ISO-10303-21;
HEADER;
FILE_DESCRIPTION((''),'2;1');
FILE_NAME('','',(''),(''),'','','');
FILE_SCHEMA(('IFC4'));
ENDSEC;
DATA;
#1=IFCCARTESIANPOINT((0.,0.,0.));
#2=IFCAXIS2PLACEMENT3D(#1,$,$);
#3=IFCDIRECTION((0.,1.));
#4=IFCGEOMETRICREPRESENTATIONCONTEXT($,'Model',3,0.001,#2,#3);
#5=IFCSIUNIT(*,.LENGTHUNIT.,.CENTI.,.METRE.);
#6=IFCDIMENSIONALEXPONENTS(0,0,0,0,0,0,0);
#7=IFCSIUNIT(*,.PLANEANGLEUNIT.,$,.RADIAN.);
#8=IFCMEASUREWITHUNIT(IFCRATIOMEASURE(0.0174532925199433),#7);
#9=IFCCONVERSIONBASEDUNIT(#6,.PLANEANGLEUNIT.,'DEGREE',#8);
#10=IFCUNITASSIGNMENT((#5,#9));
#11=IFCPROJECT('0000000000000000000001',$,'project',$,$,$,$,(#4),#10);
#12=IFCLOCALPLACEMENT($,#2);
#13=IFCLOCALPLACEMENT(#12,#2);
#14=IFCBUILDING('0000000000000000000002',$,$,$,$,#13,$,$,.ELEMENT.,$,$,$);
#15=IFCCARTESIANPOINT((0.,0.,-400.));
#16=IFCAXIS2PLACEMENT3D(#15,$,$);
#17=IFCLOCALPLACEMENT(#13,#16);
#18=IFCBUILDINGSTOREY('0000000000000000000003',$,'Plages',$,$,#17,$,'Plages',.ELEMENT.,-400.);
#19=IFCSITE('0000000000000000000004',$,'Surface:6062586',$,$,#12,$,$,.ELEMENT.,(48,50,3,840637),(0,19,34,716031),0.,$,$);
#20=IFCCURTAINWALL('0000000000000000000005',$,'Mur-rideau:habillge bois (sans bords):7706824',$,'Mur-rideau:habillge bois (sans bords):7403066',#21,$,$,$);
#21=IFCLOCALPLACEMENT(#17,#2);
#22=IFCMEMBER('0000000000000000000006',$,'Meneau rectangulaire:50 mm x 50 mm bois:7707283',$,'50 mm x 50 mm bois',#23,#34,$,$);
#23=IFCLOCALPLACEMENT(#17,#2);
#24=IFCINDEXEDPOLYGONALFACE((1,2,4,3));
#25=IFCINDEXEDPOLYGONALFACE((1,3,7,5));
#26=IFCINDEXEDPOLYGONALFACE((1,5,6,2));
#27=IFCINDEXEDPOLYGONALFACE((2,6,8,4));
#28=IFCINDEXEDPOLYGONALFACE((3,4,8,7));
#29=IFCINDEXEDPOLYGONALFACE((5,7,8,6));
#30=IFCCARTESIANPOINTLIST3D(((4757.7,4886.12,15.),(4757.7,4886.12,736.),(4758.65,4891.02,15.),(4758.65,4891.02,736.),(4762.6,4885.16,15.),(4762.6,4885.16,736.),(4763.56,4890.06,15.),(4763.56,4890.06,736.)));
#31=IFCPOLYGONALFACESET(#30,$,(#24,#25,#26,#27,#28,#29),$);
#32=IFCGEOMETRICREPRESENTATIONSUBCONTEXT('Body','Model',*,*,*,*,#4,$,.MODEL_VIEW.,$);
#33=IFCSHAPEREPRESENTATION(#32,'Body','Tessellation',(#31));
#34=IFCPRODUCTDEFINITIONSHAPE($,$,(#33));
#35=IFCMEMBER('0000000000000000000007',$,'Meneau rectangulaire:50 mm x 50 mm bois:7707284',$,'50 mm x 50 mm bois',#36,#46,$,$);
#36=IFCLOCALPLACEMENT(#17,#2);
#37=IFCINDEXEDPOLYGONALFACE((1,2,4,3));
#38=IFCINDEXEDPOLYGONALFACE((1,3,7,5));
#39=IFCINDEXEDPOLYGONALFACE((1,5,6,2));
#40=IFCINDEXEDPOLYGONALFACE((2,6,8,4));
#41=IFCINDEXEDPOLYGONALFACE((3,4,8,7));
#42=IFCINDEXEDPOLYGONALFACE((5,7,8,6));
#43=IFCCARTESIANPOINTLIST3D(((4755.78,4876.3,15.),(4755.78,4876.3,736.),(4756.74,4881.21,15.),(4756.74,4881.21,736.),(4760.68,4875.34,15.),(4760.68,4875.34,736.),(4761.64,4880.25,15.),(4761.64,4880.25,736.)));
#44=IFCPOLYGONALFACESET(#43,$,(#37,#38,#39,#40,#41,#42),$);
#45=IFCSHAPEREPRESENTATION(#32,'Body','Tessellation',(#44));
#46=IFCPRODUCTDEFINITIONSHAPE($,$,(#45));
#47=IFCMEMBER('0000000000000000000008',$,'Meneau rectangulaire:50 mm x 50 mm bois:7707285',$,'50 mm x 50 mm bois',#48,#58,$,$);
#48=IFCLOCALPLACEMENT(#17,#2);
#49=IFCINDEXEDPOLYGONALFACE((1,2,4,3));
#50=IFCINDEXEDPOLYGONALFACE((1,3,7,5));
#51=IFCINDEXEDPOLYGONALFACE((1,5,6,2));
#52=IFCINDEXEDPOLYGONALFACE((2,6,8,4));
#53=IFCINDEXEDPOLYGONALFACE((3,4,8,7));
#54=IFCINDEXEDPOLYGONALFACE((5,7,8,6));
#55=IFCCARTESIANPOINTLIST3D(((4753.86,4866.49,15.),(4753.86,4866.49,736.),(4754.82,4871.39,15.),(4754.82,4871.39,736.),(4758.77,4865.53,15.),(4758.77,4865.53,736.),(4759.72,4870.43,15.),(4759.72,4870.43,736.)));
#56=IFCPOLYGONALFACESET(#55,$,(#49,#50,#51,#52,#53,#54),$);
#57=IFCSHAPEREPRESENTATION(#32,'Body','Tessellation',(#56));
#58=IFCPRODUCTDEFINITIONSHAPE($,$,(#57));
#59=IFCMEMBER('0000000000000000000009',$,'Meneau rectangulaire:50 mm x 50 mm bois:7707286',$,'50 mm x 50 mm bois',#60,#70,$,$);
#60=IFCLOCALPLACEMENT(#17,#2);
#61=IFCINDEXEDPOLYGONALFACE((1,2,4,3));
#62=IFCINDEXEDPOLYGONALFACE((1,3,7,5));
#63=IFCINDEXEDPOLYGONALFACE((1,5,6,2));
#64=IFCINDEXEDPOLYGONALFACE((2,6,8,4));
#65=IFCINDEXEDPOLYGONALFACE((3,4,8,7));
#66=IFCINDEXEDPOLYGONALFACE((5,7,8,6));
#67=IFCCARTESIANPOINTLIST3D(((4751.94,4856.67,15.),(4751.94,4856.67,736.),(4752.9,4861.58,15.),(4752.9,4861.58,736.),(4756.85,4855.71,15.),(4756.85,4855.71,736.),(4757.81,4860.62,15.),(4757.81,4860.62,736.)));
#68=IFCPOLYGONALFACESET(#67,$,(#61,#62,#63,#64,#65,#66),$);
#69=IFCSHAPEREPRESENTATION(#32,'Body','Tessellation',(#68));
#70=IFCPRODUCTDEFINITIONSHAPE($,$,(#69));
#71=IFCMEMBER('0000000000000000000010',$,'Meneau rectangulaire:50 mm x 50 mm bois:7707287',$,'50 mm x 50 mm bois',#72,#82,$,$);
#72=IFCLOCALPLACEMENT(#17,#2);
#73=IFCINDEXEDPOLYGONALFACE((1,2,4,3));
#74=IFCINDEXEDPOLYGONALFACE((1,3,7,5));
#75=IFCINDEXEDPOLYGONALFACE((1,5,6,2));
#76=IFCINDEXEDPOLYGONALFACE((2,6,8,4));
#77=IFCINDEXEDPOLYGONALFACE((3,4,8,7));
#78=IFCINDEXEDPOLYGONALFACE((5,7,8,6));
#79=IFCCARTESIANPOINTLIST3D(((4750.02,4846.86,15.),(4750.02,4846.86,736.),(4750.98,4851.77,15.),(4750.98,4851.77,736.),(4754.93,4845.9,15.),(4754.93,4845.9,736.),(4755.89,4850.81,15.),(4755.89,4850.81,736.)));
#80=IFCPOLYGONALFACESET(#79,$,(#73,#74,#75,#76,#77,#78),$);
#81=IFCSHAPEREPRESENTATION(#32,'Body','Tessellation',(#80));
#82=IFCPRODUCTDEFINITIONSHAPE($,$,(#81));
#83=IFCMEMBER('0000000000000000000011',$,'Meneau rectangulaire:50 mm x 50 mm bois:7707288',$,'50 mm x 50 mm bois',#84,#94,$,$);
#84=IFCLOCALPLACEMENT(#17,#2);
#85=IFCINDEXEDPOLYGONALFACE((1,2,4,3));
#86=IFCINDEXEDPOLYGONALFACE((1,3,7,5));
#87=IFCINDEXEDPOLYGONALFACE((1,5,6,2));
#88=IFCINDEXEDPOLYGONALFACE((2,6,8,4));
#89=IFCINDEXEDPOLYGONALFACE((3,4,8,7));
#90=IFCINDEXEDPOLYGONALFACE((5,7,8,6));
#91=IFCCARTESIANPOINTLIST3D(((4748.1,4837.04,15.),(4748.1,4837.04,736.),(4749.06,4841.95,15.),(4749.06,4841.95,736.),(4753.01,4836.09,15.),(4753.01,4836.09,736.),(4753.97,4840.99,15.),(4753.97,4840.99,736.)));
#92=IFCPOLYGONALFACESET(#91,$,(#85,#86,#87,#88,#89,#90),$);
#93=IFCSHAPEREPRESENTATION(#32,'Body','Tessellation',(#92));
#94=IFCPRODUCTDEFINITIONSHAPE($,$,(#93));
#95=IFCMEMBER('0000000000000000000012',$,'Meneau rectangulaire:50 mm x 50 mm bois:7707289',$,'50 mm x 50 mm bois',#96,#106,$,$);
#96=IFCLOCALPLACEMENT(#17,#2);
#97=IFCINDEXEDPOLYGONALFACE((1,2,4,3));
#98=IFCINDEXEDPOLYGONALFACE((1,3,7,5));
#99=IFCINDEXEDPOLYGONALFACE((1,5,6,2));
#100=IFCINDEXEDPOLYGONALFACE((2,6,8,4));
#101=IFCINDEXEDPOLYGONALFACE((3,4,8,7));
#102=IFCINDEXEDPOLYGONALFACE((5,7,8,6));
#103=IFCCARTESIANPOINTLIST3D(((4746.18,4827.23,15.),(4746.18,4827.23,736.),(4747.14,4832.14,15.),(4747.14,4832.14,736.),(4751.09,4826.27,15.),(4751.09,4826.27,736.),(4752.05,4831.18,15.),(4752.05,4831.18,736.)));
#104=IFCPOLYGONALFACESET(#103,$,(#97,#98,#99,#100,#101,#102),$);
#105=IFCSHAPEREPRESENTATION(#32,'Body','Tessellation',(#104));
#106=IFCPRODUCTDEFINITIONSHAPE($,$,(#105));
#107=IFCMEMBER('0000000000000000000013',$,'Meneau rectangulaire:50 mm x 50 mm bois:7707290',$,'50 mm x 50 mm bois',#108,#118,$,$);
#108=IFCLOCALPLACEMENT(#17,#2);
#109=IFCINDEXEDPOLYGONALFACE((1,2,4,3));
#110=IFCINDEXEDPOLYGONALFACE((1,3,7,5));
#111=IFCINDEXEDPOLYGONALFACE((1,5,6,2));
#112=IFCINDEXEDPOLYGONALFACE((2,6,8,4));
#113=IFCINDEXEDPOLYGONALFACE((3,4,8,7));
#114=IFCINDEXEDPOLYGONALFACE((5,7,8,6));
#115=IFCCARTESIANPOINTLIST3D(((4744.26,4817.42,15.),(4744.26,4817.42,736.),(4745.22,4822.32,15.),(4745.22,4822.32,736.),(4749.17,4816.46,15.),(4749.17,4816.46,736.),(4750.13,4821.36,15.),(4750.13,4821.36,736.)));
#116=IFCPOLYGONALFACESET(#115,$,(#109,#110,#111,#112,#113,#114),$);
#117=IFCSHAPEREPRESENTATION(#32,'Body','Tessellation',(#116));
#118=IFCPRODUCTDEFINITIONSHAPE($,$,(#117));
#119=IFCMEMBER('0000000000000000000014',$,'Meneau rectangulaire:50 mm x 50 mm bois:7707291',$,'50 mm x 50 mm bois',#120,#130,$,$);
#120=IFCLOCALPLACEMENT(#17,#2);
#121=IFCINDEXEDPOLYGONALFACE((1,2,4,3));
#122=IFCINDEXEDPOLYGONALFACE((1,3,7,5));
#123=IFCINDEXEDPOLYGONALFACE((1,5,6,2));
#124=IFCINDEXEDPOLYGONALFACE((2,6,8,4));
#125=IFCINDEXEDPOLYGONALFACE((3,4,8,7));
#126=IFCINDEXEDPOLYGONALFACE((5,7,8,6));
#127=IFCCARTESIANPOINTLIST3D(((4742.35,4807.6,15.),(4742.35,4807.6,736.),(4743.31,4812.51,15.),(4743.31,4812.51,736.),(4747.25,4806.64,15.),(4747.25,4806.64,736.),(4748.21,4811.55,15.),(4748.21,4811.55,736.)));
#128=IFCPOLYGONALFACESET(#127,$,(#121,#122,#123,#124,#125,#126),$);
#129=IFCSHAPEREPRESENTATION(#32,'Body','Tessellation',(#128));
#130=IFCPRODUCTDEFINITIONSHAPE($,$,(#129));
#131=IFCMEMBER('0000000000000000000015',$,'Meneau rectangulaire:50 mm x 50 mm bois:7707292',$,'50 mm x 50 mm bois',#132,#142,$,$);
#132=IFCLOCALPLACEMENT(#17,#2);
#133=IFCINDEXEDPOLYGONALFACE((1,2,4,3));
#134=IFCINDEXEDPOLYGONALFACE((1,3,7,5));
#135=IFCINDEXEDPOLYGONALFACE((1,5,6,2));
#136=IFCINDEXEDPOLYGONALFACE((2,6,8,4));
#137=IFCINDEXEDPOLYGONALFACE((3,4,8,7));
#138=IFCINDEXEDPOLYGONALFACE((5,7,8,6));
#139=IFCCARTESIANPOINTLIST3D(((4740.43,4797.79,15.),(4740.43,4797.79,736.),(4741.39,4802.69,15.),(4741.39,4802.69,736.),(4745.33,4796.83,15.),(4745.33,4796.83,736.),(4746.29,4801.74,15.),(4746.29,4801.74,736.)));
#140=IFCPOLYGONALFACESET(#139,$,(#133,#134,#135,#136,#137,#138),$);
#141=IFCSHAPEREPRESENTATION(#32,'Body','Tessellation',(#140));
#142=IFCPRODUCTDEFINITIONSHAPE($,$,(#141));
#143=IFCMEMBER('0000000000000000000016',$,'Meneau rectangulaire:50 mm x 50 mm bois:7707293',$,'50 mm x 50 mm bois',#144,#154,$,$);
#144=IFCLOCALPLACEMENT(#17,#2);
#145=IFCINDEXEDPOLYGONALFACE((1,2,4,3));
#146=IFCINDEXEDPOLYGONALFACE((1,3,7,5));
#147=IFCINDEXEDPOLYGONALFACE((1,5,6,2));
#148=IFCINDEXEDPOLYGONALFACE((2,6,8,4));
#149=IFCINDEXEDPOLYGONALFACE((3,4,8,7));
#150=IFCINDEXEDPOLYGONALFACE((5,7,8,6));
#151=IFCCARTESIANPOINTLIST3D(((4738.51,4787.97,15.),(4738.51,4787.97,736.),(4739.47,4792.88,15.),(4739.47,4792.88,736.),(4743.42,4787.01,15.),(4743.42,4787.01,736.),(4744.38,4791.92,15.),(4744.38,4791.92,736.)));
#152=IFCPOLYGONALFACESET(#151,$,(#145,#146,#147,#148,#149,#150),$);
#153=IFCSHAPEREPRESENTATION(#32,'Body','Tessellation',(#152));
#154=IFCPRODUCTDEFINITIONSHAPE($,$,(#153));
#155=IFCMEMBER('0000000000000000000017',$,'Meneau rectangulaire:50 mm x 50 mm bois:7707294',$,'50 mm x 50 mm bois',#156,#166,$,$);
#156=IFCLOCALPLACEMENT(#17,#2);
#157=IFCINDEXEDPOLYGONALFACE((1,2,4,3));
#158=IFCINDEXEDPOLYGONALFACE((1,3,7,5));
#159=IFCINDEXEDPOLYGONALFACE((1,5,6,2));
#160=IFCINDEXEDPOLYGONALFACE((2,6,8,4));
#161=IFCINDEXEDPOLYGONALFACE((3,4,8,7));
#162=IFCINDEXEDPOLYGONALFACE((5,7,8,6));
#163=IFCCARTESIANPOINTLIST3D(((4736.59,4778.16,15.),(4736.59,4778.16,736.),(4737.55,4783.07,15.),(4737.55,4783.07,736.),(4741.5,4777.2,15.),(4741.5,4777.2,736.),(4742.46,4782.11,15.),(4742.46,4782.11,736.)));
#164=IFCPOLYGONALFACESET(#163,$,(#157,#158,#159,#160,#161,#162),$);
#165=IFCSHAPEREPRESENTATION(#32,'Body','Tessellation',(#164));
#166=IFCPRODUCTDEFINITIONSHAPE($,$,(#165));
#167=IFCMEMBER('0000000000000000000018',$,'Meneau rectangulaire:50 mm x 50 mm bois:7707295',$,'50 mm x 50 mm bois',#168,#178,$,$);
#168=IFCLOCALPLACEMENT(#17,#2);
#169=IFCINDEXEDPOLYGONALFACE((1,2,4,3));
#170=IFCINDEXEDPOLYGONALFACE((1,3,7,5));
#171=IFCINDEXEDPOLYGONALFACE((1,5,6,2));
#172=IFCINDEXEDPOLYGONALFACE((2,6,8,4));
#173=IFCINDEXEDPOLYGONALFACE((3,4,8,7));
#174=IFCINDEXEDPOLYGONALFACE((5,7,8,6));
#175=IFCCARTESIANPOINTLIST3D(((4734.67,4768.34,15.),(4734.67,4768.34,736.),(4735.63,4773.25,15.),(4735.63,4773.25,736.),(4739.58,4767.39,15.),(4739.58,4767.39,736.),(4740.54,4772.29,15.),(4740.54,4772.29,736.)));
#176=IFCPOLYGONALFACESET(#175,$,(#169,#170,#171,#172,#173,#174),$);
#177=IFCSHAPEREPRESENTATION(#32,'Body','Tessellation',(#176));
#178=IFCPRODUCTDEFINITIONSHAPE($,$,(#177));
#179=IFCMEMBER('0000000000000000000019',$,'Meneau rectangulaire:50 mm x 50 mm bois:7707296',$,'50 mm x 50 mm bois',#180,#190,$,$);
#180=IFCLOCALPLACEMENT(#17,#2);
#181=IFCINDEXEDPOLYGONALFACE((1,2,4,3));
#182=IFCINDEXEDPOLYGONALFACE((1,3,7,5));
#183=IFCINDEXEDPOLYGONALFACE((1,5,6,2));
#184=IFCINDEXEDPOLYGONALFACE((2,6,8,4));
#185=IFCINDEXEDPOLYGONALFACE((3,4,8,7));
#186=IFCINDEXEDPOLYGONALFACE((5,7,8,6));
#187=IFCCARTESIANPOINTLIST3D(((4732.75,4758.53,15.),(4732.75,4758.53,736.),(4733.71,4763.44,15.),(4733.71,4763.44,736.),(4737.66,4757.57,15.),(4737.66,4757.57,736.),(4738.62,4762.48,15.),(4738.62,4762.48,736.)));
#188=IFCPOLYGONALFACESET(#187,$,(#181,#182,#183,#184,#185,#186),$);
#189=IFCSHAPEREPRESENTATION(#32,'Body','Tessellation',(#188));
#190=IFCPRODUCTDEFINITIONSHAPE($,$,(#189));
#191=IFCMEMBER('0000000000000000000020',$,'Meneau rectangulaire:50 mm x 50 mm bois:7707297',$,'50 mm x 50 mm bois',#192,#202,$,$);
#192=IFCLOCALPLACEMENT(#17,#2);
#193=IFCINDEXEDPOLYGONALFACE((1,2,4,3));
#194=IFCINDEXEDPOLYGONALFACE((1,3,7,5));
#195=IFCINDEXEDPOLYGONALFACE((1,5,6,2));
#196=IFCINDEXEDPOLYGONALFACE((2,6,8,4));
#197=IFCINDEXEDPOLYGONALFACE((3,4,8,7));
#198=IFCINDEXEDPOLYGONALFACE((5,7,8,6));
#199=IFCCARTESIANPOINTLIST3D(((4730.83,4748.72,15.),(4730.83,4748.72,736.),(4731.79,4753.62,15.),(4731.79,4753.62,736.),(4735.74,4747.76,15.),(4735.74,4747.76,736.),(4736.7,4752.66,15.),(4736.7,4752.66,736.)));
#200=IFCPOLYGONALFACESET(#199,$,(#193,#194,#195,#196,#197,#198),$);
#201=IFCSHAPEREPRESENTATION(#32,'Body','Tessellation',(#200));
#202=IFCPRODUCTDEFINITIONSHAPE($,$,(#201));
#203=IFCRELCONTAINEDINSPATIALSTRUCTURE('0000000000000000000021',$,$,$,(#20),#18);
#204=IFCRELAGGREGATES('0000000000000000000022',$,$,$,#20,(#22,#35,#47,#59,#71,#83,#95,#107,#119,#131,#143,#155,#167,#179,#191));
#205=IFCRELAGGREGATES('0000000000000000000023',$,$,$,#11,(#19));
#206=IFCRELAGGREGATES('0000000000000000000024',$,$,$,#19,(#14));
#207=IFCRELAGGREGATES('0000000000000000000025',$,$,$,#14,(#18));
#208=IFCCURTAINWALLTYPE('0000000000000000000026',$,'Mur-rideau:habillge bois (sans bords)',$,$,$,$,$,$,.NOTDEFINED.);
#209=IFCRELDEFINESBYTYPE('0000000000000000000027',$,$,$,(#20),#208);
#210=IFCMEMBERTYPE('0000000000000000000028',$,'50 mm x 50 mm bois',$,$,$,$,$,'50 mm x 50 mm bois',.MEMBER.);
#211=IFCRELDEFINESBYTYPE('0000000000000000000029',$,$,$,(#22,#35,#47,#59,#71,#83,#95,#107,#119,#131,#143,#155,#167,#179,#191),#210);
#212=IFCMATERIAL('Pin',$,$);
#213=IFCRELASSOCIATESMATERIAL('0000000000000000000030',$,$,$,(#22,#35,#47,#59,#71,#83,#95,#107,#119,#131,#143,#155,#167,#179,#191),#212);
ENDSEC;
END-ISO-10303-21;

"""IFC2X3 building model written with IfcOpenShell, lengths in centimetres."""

from ifc_helpers import new_model, entity, si_unit, converted_unit, direction, frame, origin, origin_2d_with_axis, place, context, subcontext, project, spatial, rectangle, extrude, source, transform, mapped, material, type_object, type_shapes, element, aggregate, save


model = new_model("IFC2X3")

# Units and contexts
model_context = context("Model", 3, precision=0.001, world=origin(), true_north=direction((0.0, 1.0)))
body_context = subcontext(model_context, "Body", "Model", "MODEL_VIEW")
ifc_project = project(units=[si_unit("LENGTHUNIT", "METRE", prefix="CENTI"), converted_unit("PLANEANGLEUNIT", "DEGREE", entity("IfcRatioMeasure", 0.0174532925199433), si_unit("PLANEANGLEUNIT", "RADIAN"), dimensions=[0, 0, 0, 0, 0, 0, 0])], contexts=[model_context])

# Site, building, storey
site_placement = place(None, origin())
site = spatial("IfcSite", under=ifc_project, at=site_placement, Name="Surface:6062586", CompositionType="ELEMENT", RefLatitude=(48, 50, 3, 840637), RefLongitude=(0, 19, 34, 716031), RefElevation=0.0)
building_placement = place(site_placement, origin())
building = spatial("IfcBuilding", under=site, at=building_placement, CompositionType="ELEMENT")
storey_placement = place(building_placement, frame((0.0, 0.0, -400.0)))
storey = spatial("IfcBuildingStorey", under=building, at=storey_placement, Name="Plages", LongName="Plages", CompositionType="ELEMENT", Elevation=-400.0)

# Curtain wall, members
curtain_wall_type = type_object("IfcCurtainWallType", Name="Mur-rideau:habillge bois (sans bords)", PredefinedType="NOTDEFINED")
curtain_wall_placement = place(storey_placement, frame((0.0, 0.0, 400.0)))
curtain_wall = element("IfcCurtainWall", 1, at=curtain_wall_placement, inside=storey, type_object=curtain_wall_type, Name="Mur-rideau:habillge bois (sans bords):7706824", ObjectType="Mur-rideau:habillge bois (sans bords):7403066")
ifc_material = material(Name="Pin")
member_type = type_object("IfcMemberType", Name="50 mm x 50 mm bois", ElementType="50 mm x 50 mm bois", PredefinedType="MEMBER")
shared_shape = source(origin(), body_context, "Body", "SweptSolid", [
    extrude(rectangle(XDim=5.0, YDim=5.0, at=origin_2d_with_axis()), frame((0.0, 0.0, -721.0), z_axis=(0.0, 0.0, 1.0), x_axis=(0.0, -1.0, 0.0)), (0.0, 0.0, 1.0), 721.0),
])
type_shapes(member_type, [shared_shape])
placement = place(building_placement, frame((0.0, 0.0, 336.0)))
member_1_placement = place(placement, frame((4760.63, 4888.09, -721.0), z_axis=(0.0, 0.0, -1.0), x_axis=(0.191861, 0.981422, 0.0)))
member_1 = element("IfcMember", 2, at=member_1_placement, type_object=member_type, material=ifc_material, Name="Meneau rectangulaire:50 mm x 50 mm bois:7707283", ObjectType="50 mm x 50 mm bois", context=body_context, shape_type="MappedRepresentation", body=[
    mapped(shared_shape, transform((0.0, 0.0, 0.0), scale=1.0)),
])
member_2_placement = place(placement, frame((4758.71, 4878.28, -721.0), z_axis=(0.0, 0.0, -1.0), x_axis=(0.191861, 0.981422, 0.0)))
member_2 = element("IfcMember", 3, at=member_2_placement, type_object=member_type, material=ifc_material, Name="Meneau rectangulaire:50 mm x 50 mm bois:7707284", ObjectType="50 mm x 50 mm bois", context=body_context, shape_type="MappedRepresentation", body=[
    mapped(shared_shape, transform((0.0, 0.0, 0.0), scale=1.0)),
])
member_3_placement = place(placement, frame((4756.79, 4868.46, -721.0), z_axis=(0.0, 0.0, -1.0), x_axis=(0.191861, 0.981422, 0.0)))
member_3 = element("IfcMember", 4, at=member_3_placement, type_object=member_type, material=ifc_material, Name="Meneau rectangulaire:50 mm x 50 mm bois:7707285", ObjectType="50 mm x 50 mm bois", context=body_context, shape_type="MappedRepresentation", body=[
    mapped(shared_shape, transform((0.0, 0.0, 0.0), scale=1.0)),
])
member_4_placement = place(placement, frame((4754.87, 4858.65, -721.0), z_axis=(0.0, 0.0, -1.0), x_axis=(0.191861, 0.981422, 0.0)))
member_4 = element("IfcMember", 5, at=member_4_placement, type_object=member_type, material=ifc_material, Name="Meneau rectangulaire:50 mm x 50 mm bois:7707286", ObjectType="50 mm x 50 mm bois", context=body_context, shape_type="MappedRepresentation", body=[
    mapped(shared_shape, transform((0.0, 0.0, 0.0), scale=1.0)),
])
member_5_placement = place(placement, frame((4752.95, 4848.83, -721.0), z_axis=(0.0, 0.0, -1.0), x_axis=(0.191861, 0.981422, 0.0)))
member_5 = element("IfcMember", 6, at=member_5_placement, type_object=member_type, material=ifc_material, Name="Meneau rectangulaire:50 mm x 50 mm bois:7707287", ObjectType="50 mm x 50 mm bois", context=body_context, shape_type="MappedRepresentation", body=[
    mapped(shared_shape, transform((0.0, 0.0, 0.0), scale=1.0)),
])
member_6_placement = place(placement, frame((4751.04, 4839.02, -721.0), z_axis=(0.0, 0.0, -1.0), x_axis=(0.191861, 0.981422, 0.0)))
member_6 = element("IfcMember", 7, at=member_6_placement, type_object=member_type, material=ifc_material, Name="Meneau rectangulaire:50 mm x 50 mm bois:7707288", ObjectType="50 mm x 50 mm bois", context=body_context, shape_type="MappedRepresentation", body=[
    mapped(shared_shape, transform((0.0, 0.0, 0.0), scale=1.0)),
])
member_7_placement = place(placement, frame((4749.12, 4829.2, -721.0), z_axis=(0.0, 0.0, -1.0), x_axis=(0.191861, 0.981422, 0.0)))
member_7 = element("IfcMember", 8, at=member_7_placement, type_object=member_type, material=ifc_material, Name="Meneau rectangulaire:50 mm x 50 mm bois:7707289", ObjectType="50 mm x 50 mm bois", context=body_context, shape_type="MappedRepresentation", body=[
    mapped(shared_shape, transform((0.0, 0.0, 0.0), scale=1.0)),
])
member_8_placement = place(placement, frame((4747.2, 4819.39, -721.0), z_axis=(0.0, 0.0, -1.0), x_axis=(0.191861, 0.981422, 0.0)))
member_8 = element("IfcMember", 9, at=member_8_placement, type_object=member_type, material=ifc_material, Name="Meneau rectangulaire:50 mm x 50 mm bois:7707290", ObjectType="50 mm x 50 mm bois", context=body_context, shape_type="MappedRepresentation", body=[
    mapped(shared_shape, transform((0.0, 0.0, 0.0), scale=1.0)),
])
member_9_placement = place(placement, frame((4745.28, 4809.58, -721.0), z_axis=(0.0, 0.0, -1.0), x_axis=(0.191861, 0.981422, 0.0)))
member_9 = element("IfcMember", 10, at=member_9_placement, type_object=member_type, material=ifc_material, Name="Meneau rectangulaire:50 mm x 50 mm bois:7707291", ObjectType="50 mm x 50 mm bois", context=body_context, shape_type="MappedRepresentation", body=[
    mapped(shared_shape, transform((0.0, 0.0, 0.0), scale=1.0)),
])
member_10_placement = place(placement, frame((4743.36, 4799.76, -721.0), z_axis=(0.0, 0.0, -1.0), x_axis=(0.191861, 0.981422, 0.0)))
member_10 = element("IfcMember", 11, at=member_10_placement, type_object=member_type, material=ifc_material, Name="Meneau rectangulaire:50 mm x 50 mm bois:7707292", ObjectType="50 mm x 50 mm bois", context=body_context, shape_type="MappedRepresentation", body=[
    mapped(shared_shape, transform((0.0, 0.0, 0.0), scale=1.0)),
])
member_11_placement = place(placement, frame((4741.44, 4789.95, -721.0), z_axis=(0.0, 0.0, -1.0), x_axis=(0.191861, 0.981422, 0.0)))
member_11 = element("IfcMember", 12, at=member_11_placement, type_object=member_type, material=ifc_material, Name="Meneau rectangulaire:50 mm x 50 mm bois:7707293", ObjectType="50 mm x 50 mm bois", context=body_context, shape_type="MappedRepresentation", body=[
    mapped(shared_shape, transform((0.0, 0.0, 0.0), scale=1.0)),
])
member_12_placement = place(placement, frame((4739.52, 4780.13, -721.0), z_axis=(0.0, 0.0, -1.0), x_axis=(0.191861, 0.981422, 0.0)))
member_12 = element("IfcMember", 13, at=member_12_placement, type_object=member_type, material=ifc_material, Name="Meneau rectangulaire:50 mm x 50 mm bois:7707294", ObjectType="50 mm x 50 mm bois", context=body_context, shape_type="MappedRepresentation", body=[
    mapped(shared_shape, transform((0.0, 0.0, 0.0), scale=1.0)),
])
member_13_placement = place(placement, frame((4737.61, 4770.32, -721.0), z_axis=(0.0, 0.0, -1.0), x_axis=(0.191861, 0.981422, 0.0)))
member_13 = element("IfcMember", 14, at=member_13_placement, type_object=member_type, material=ifc_material, Name="Meneau rectangulaire:50 mm x 50 mm bois:7707295", ObjectType="50 mm x 50 mm bois", context=body_context, shape_type="MappedRepresentation", body=[
    mapped(shared_shape, transform((0.0, 0.0, 0.0), scale=1.0)),
])
member_14_placement = place(placement, frame((4735.69, 4760.5, -721.0), z_axis=(0.0, 0.0, -1.0), x_axis=(0.191861, 0.981422, 0.0)))
member_14 = element("IfcMember", 15, at=member_14_placement, type_object=member_type, material=ifc_material, Name="Meneau rectangulaire:50 mm x 50 mm bois:7707296", ObjectType="50 mm x 50 mm bois", context=body_context, shape_type="MappedRepresentation", body=[
    mapped(shared_shape, transform((0.0, 0.0, 0.0), scale=1.0)),
])
member_15_placement = place(placement, frame((4733.77, 4750.69, -721.0), z_axis=(0.0, 0.0, -1.0), x_axis=(0.191861, 0.981422, 0.0)))
member_15 = element("IfcMember", 16, at=member_15_placement, type_object=member_type, material=ifc_material, Name="Meneau rectangulaire:50 mm x 50 mm bois:7707297", ObjectType="50 mm x 50 mm bois", context=body_context, shape_type="MappedRepresentation", body=[
    mapped(shared_shape, transform((0.0, 0.0, 0.0), scale=1.0)),
])
aggregate(curtain_wall, [member_1, member_2, member_3, member_4, member_5, member_6, member_7, member_8, member_9, member_10, member_11, member_12, member_13, member_14, member_15])

save(model, "model.ifc")
